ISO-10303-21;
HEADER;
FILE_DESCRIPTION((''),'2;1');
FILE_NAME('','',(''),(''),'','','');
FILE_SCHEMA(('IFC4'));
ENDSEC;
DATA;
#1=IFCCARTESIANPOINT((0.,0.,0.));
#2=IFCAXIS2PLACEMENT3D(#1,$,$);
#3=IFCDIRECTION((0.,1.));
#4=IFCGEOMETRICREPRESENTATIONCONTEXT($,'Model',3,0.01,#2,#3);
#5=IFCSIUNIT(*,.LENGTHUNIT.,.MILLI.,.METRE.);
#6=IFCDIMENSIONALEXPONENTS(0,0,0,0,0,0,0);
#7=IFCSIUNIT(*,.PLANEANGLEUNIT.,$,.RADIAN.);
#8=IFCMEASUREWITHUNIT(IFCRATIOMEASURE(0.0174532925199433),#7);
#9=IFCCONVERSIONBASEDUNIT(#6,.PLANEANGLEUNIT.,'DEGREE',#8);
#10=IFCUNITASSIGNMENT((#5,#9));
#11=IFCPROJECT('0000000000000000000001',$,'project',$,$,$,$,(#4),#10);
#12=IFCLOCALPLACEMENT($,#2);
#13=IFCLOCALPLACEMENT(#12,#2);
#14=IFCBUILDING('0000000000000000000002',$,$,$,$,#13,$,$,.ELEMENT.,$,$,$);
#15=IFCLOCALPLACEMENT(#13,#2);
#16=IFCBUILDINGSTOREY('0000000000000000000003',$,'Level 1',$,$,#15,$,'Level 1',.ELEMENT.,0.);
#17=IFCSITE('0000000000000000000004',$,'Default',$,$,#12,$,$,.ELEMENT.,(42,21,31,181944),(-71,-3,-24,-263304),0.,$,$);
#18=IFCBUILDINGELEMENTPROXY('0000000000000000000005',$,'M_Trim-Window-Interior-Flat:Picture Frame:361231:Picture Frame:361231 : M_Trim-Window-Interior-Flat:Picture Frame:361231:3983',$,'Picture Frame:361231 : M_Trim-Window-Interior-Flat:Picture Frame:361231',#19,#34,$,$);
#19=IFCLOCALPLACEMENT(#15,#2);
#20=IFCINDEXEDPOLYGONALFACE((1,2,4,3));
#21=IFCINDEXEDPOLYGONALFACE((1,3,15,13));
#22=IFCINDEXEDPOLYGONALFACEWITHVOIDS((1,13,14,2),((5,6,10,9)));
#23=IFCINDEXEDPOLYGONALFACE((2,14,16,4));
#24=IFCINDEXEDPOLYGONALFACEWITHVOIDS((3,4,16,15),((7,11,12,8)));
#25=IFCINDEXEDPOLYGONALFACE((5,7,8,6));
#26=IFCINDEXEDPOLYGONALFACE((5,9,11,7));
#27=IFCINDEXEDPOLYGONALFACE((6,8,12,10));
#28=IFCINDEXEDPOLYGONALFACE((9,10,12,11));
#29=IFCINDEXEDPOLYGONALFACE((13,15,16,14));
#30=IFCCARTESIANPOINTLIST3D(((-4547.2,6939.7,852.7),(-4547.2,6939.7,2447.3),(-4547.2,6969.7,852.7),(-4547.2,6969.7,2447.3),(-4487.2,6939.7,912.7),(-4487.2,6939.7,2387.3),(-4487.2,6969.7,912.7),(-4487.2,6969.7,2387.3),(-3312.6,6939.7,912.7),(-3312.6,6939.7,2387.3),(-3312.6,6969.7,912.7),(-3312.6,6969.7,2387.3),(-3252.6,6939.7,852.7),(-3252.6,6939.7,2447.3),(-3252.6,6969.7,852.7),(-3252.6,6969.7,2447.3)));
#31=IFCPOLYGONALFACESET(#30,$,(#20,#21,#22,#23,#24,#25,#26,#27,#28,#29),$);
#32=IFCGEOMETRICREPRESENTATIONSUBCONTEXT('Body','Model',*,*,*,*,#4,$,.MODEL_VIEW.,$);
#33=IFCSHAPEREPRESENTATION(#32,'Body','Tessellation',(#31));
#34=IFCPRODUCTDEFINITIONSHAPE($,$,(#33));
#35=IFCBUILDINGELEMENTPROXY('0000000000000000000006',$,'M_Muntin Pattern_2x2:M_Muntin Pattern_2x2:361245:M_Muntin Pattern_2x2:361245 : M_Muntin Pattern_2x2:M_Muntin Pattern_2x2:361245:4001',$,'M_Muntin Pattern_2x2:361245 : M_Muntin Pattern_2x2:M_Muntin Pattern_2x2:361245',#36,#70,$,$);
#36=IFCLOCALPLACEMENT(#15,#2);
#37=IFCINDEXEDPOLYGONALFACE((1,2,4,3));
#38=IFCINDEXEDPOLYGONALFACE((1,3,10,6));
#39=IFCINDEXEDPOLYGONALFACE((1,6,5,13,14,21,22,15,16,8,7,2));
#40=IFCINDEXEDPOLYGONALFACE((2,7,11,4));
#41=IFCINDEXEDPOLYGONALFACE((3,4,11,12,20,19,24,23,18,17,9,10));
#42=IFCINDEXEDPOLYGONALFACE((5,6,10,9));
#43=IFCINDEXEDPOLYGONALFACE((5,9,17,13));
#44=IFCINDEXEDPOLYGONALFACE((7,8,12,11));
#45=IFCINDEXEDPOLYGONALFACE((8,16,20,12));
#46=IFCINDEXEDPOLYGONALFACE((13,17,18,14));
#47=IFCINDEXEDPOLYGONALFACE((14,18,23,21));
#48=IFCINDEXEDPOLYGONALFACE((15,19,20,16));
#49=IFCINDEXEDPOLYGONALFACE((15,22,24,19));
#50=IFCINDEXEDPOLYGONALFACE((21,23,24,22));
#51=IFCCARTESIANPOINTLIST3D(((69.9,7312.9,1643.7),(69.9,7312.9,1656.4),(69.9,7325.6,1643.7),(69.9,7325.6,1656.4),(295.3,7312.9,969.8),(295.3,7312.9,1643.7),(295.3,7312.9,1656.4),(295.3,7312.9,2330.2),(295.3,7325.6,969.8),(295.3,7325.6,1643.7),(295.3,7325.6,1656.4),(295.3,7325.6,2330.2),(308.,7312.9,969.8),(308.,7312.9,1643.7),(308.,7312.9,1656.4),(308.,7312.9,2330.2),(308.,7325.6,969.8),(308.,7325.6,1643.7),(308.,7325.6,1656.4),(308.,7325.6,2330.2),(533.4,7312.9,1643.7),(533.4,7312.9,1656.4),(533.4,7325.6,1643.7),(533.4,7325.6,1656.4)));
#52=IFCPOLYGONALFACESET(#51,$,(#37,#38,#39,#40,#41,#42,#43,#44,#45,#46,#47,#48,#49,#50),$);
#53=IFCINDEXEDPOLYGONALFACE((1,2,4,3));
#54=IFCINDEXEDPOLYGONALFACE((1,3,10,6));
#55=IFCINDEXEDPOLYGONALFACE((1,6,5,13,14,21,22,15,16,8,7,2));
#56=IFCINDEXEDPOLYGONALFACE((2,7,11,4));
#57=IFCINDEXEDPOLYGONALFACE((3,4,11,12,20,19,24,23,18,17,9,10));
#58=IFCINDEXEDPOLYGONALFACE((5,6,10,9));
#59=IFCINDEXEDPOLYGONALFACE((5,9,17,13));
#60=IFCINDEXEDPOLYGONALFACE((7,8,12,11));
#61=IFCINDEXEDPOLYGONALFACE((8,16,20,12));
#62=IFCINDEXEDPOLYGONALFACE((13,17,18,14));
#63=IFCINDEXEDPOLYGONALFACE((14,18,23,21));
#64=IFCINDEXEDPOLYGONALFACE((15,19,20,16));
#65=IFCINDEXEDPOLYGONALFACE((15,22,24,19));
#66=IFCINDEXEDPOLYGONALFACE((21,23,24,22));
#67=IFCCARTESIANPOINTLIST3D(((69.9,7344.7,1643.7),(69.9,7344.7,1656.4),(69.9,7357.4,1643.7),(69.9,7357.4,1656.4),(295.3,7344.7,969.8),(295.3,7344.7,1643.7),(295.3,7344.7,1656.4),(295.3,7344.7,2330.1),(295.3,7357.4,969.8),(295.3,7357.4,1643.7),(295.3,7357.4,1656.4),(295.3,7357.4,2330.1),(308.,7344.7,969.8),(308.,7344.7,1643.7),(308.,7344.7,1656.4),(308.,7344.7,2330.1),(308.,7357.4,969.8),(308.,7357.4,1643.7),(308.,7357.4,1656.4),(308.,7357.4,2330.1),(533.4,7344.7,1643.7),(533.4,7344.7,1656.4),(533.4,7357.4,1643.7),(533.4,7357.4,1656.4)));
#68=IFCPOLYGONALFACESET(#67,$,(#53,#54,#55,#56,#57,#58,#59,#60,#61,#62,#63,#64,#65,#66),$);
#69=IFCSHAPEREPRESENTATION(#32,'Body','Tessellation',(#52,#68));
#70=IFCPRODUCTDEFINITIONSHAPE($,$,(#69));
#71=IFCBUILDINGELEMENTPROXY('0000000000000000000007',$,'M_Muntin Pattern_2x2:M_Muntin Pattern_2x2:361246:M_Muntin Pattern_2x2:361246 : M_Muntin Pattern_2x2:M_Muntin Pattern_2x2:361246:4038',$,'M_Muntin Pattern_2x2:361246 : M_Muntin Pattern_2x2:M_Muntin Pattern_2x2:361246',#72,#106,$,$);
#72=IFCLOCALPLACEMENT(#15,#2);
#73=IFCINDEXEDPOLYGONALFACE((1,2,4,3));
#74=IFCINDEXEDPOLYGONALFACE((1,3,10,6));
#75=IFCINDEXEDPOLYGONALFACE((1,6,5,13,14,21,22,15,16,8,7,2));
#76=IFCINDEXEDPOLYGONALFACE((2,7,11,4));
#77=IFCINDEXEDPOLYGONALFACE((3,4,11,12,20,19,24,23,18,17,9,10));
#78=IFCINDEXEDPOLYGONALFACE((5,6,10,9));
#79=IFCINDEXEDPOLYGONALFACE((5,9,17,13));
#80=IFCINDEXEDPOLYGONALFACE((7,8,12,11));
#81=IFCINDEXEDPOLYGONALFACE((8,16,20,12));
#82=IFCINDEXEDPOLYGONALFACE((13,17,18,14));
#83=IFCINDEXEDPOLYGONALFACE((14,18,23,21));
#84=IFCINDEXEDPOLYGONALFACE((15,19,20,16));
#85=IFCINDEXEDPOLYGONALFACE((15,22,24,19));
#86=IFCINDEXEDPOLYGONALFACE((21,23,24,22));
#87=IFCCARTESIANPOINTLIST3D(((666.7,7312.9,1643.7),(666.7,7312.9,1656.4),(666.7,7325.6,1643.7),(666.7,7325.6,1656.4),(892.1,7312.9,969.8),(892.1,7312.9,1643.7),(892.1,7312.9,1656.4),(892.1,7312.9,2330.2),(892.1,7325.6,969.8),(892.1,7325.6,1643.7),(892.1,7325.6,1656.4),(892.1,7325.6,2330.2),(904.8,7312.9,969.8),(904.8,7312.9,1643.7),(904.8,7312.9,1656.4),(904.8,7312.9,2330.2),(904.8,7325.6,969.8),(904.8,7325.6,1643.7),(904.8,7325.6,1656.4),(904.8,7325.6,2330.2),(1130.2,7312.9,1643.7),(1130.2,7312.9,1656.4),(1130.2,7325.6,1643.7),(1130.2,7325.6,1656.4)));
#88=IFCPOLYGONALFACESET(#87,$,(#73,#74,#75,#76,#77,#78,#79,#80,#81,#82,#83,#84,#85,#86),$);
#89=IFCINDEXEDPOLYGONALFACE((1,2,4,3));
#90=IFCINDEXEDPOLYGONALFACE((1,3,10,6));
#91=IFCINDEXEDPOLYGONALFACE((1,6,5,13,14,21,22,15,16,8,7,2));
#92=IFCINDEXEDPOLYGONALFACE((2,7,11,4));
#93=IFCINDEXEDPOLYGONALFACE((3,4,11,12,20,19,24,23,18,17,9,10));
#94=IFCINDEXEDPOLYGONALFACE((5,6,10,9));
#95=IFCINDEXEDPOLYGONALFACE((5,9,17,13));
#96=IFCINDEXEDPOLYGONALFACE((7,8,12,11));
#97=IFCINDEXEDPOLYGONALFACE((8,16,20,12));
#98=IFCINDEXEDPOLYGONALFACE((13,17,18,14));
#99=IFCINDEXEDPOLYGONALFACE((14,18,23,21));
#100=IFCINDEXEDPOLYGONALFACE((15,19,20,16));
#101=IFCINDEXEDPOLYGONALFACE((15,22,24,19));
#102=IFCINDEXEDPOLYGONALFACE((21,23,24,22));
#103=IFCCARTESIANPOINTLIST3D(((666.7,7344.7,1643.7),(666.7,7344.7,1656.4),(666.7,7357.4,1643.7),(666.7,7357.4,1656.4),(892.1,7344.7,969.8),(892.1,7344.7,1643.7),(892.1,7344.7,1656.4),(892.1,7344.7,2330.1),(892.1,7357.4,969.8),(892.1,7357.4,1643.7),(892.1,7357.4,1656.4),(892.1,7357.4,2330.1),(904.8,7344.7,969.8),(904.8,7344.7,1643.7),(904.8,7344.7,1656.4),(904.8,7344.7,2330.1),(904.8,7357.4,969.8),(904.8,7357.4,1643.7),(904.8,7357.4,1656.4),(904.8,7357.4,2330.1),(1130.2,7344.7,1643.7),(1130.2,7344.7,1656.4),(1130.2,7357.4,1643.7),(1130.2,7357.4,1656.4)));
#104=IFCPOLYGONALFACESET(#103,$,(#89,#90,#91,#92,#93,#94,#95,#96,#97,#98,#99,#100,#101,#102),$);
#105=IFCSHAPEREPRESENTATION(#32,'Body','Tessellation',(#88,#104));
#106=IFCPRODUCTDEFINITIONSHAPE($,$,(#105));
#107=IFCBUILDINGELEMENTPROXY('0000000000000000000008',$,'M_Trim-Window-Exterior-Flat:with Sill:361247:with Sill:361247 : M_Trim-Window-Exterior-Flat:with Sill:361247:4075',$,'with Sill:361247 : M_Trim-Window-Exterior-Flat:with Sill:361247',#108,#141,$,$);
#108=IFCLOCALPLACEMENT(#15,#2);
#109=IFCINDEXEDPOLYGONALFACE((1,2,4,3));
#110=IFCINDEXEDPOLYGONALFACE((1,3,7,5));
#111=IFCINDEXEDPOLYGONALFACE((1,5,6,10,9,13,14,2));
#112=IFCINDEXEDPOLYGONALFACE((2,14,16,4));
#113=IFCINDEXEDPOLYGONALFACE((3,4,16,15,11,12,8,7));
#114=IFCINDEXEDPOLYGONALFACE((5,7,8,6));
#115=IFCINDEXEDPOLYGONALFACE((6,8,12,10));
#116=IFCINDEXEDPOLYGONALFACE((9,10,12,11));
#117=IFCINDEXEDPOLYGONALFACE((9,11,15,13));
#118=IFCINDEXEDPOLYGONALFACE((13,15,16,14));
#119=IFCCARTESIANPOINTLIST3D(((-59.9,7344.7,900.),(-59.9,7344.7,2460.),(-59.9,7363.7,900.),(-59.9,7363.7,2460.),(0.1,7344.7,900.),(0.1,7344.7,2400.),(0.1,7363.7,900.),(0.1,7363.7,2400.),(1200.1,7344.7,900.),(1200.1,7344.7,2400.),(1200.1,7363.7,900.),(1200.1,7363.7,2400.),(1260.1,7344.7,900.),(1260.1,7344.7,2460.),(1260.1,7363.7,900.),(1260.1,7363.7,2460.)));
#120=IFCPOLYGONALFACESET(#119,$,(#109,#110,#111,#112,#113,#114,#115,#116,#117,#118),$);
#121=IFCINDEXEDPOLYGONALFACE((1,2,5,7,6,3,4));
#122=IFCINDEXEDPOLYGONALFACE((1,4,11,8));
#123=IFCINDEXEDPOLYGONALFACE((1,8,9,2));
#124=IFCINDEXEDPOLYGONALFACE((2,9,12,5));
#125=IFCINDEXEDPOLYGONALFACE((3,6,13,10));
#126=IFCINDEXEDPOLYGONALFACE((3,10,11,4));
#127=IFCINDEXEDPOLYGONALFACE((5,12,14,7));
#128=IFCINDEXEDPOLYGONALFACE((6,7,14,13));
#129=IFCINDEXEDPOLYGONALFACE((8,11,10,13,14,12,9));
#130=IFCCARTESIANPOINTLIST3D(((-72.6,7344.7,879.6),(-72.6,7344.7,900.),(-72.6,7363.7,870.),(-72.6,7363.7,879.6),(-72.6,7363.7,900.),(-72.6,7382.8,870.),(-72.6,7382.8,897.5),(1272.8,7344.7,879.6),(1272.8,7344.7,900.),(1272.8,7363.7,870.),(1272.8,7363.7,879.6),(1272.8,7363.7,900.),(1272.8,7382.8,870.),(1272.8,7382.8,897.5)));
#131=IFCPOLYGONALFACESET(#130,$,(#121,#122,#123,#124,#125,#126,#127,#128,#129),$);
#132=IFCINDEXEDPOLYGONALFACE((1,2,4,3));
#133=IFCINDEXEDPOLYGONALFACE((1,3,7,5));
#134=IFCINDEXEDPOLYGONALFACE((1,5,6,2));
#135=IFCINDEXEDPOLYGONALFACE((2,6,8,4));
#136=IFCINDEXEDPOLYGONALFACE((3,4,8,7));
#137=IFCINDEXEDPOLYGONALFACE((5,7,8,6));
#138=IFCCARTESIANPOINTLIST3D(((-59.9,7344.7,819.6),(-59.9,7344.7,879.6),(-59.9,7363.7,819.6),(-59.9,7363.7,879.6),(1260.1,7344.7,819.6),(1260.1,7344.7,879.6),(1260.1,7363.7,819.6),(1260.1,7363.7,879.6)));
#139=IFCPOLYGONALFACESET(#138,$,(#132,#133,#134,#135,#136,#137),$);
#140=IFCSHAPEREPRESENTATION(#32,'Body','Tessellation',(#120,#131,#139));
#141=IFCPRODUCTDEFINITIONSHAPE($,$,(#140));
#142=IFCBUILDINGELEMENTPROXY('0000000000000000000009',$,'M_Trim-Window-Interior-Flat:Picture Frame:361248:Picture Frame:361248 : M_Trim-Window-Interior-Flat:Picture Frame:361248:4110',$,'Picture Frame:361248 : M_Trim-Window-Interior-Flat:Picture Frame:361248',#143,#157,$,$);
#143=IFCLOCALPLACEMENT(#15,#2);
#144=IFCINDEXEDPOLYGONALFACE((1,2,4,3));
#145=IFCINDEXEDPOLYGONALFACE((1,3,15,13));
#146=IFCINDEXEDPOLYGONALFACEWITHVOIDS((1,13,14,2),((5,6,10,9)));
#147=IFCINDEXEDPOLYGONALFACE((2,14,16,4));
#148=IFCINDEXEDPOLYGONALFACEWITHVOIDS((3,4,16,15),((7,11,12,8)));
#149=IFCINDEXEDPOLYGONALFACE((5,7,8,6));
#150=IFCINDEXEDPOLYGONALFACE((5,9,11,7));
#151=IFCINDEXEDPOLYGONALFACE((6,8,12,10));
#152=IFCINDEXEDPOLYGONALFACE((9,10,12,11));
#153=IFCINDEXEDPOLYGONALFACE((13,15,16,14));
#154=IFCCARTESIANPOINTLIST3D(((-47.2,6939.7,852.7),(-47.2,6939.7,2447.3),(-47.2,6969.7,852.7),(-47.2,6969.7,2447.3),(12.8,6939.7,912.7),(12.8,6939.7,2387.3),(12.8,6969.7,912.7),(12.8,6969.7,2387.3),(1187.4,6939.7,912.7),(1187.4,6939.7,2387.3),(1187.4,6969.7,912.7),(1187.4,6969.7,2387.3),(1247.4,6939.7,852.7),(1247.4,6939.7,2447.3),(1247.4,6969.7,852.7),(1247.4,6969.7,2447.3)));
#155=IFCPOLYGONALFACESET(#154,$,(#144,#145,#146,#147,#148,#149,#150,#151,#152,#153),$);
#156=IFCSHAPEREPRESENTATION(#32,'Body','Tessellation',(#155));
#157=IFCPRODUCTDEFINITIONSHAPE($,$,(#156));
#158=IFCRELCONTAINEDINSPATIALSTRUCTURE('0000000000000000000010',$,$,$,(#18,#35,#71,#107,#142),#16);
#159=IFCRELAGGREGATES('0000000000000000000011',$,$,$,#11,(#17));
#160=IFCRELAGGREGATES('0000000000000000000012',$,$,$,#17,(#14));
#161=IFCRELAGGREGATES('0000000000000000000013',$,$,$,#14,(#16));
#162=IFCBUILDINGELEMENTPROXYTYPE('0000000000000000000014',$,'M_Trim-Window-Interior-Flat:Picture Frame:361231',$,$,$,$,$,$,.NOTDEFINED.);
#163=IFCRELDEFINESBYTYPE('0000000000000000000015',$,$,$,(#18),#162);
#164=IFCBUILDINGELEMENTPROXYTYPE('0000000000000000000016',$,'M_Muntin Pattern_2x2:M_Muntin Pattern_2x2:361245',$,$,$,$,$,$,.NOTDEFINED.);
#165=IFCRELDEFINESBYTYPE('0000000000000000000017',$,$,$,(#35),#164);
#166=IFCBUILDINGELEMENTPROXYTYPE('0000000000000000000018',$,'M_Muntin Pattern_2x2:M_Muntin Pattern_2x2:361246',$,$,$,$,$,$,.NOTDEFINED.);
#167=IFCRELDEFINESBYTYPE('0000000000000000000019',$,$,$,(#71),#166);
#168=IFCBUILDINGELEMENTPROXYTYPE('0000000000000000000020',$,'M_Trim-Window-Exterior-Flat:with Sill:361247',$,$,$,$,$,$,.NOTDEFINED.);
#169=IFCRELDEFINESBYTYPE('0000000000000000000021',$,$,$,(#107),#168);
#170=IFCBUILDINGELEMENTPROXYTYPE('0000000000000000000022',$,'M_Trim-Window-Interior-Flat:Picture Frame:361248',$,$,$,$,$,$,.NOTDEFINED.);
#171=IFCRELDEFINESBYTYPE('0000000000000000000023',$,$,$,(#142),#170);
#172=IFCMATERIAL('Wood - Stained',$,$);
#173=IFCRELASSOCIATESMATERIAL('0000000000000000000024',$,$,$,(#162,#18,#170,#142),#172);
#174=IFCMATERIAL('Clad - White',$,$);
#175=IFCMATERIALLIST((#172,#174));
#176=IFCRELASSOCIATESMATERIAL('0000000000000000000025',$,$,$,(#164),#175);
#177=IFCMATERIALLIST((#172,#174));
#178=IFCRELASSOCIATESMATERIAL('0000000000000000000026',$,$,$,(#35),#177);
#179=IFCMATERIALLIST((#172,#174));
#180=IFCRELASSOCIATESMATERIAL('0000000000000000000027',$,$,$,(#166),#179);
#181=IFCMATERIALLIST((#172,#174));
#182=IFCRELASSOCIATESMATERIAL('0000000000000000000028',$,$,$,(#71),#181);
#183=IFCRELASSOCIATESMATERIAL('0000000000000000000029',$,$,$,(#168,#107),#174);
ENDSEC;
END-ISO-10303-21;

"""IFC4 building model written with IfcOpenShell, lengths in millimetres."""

from ifc_helpers import new_model, entity, si_unit, converted_unit, direction, frame, origin, origin_2d_with_axis, place, context, subcontext, project, spatial, polyline, rectangle, outline, extrude, source, transform, mapped, material, material_list, type_object, type_shapes, element, save


model = new_model("IFC4")

# Units and contexts
model_context = context("Model", 3, precision=0.01, world=origin(), true_north=direction((0.0, 1.0)))
body_context = subcontext(model_context, "Body", "Model", "MODEL_VIEW")
ifc_project = project(units=[si_unit("LENGTHUNIT", "METRE", prefix="MILLI"), converted_unit("PLANEANGLEUNIT", "DEGREE", entity("IfcRatioMeasure", 0.0174532925199433), si_unit("PLANEANGLEUNIT", "RADIAN"), dimensions=[0, 0, 0, 0, 0, 0, 0])], contexts=[model_context])

# Site, building, storey
site_placement = place(None, origin())
site = spatial("IfcSite", under=ifc_project, at=site_placement, Name="Default", CompositionType="ELEMENT", RefLatitude=(42, 21, 31, 181944), RefLongitude=(-71, -3, -24, -263304), RefElevation=0.0)
building_placement = place(site_placement, origin())
building = spatial("IfcBuilding", under=site, at=building_placement, CompositionType="ELEMENT")
storey_placement = place(building_placement, origin())
storey = spatial("IfcBuildingStorey", under=building, at=storey_placement, Name="Level 1", LongName="Level 1", CompositionType="ELEMENT", Elevation=0.0)

# Building element proxies
ifc_material_1 = material(Name="Wood - Stained")
ifc_material_2 = material(Name="Clad - White")
building_element_proxy_type_1 = type_object("IfcBuildingElementProxyType", Name="M_Trim-Window-Interior-Flat:Picture Frame:361231", PredefinedType="NOTDEFINED", material=ifc_material_1)
shared_shape_1 = source(origin(), body_context, "Body", "SweptSolid", [
    extrude(outline(polyline([(-647.3, -797.3), (647.3, -797.3), (647.3, 797.3), (-647.3, 797.3), (-647.3, -797.3)]), holes=[polyline([(587.3, 737.3), (587.3, -737.3), (-587.3, -737.3), (-587.3, 737.3), (587.3, 737.3)])]), frame((-3899.9, 6939.7, 1650.0), z_axis=(0.0, 1.0, 0.0), x_axis=(1.0, 0.0, 0.0)), (0.0, 0.0, 1.0), 30.0),
])
type_shapes(building_element_proxy_type_1, [shared_shape_1])
proxy_1_placement = place(storey_placement, origin())
element("IfcBuildingElementProxy", 1, at=proxy_1_placement, inside=storey, type_object=building_element_proxy_type_1, material=ifc_material_1, Name="M_Trim-Window-Interior-Flat:Picture Frame:361231:Picture Frame:361231 : M_Trim-Window-Interior-Flat:Picture Frame:361231:3983", ObjectType="Picture Frame:361231 : M_Trim-Window-Interior-Flat:Picture Frame:361231", context=body_context, shape_type="MappedRepresentation", body=[
    mapped(shared_shape_1, transform((0.0, 0.0, 0.0), scale=1.0)),
])
ifc_material_list_1 = material_list([ifc_material_1, ifc_material_2])
ifc_material_list_2 = material_list([ifc_material_1, ifc_material_2])
building_element_proxy_type_2 = type_object("IfcBuildingElementProxyType", Name="M_Muntin Pattern_2x2:M_Muntin Pattern_2x2:361245", PredefinedType="NOTDEFINED", material=ifc_material_list_2)
shared_shape_2 = source(origin(), body_context, "Body", "SweptSolid", [
    extrude(outline(polyline([(-6.4, -680.2), (6.3, -680.2), (6.3, -6.4), (231.7, -6.4), (231.7, 6.3), (6.3, 6.3), (6.3, 680.2), (-6.4, 680.2), (-6.4, 6.3), (-231.7, 6.3), (-231.7, -6.4), (-6.4, -6.4), (-6.4, -680.2)])), frame((301.6, 7312.9, 1650.0), z_axis=(0.0, 1.0, 0.0), x_axis=(1.0, 0.0, 0.0)), (0.0, 0.0, 1.0), 12.7),
    extrude(outline(polyline([(-6.4, -680.1), (6.3, -680.1), (6.3, -6.4), (231.7, -6.4), (231.7, 6.3), (6.3, 6.3), (6.3, 680.2), (-6.4, 680.2), (-6.4, 6.3), (-231.7, 6.3), (-231.7, -6.4), (-6.4, -6.4), (-6.4, -680.1)])), frame((301.6, 7344.7, 1650.0), z_axis=(0.0, 1.0, 0.0), x_axis=(1.0, 0.0, 0.0)), (0.0, 0.0, 1.0), 12.7),
])
type_shapes(building_element_proxy_type_2, [shared_shape_2])
proxy_2_placement = place(storey_placement, origin())
element("IfcBuildingElementProxy", 2, at=proxy_2_placement, inside=storey, type_object=building_element_proxy_type_2, material=ifc_material_list_1, Name="M_Muntin Pattern_2x2:M_Muntin Pattern_2x2:361245:M_Muntin Pattern_2x2:361245 : M_Muntin Pattern_2x2:M_Muntin Pattern_2x2:361245:4001", ObjectType="M_Muntin Pattern_2x2:361245 : M_Muntin Pattern_2x2:M_Muntin Pattern_2x2:361245", context=body_context, shape_type="MappedRepresentation", body=[
    mapped(shared_shape_2, transform((0.0, 0.0, 0.0), scale=1.0)),
])
ifc_material_list_3 = material_list([ifc_material_1, ifc_material_2])
ifc_material_list_4 = material_list([ifc_material_1, ifc_material_2])
building_element_proxy_type_3 = type_object("IfcBuildingElementProxyType", Name="M_Muntin Pattern_2x2:M_Muntin Pattern_2x2:361246", PredefinedType="NOTDEFINED", material=ifc_material_list_4)
shared_shape_3 = source(origin(), body_context, "Body", "SweptSolid", [
    extrude(outline(polyline([(-680.1, 6.4), (-680.1, -6.3), (-6.4, -6.3), (-6.4, -231.7), (6.3, -231.7), (6.3, -6.3), (680.2, -6.3), (680.2, 6.4), (6.3, 6.4), (6.3, 231.7), (-6.4, 231.7), (-6.4, 6.4), (-680.1, 6.4)])), frame((898.5, 7312.9, 1650.0), z_axis=(0.0, -1.0, 0.0), x_axis=(0.0, 0.0, -1.0)), (0.0, 0.0, -1.0), 12.7),
    extrude(outline(polyline([(-680.1, 6.4), (-680.1, -6.3), (-6.4, -6.3), (-6.4, -231.7), (6.3, -231.7), (6.3, -6.3), (680.2, -6.3), (680.2, 6.4), (6.3, 6.4), (6.3, 231.7), (-6.4, 231.7), (-6.4, 6.4), (-680.1, 6.4)])), frame((898.5, 7344.7, 1650.0), z_axis=(0.0, -1.0, 0.0), x_axis=(0.0, 0.0, -1.0)), (0.0, 0.0, -1.0), 12.7),
])
type_shapes(building_element_proxy_type_3, [shared_shape_3])
proxy_3_placement = place(storey_placement, origin())
element("IfcBuildingElementProxy", 3, at=proxy_3_placement, inside=storey, type_object=building_element_proxy_type_3, material=ifc_material_list_3, Name="M_Muntin Pattern_2x2:M_Muntin Pattern_2x2:361246:M_Muntin Pattern_2x2:361246 : M_Muntin Pattern_2x2:M_Muntin Pattern_2x2:361246:4038", ObjectType="M_Muntin Pattern_2x2:361246 : M_Muntin Pattern_2x2:M_Muntin Pattern_2x2:361246", context=body_context, shape_type="MappedRepresentation", body=[
    mapped(shared_shape_3, transform((0.0, 0.0, 0.0), scale=1.0)),
])
building_element_proxy_type_4 = type_object("IfcBuildingElementProxyType", Name="M_Trim-Window-Exterior-Flat:with Sill:361247", PredefinedType="NOTDEFINED", material=ifc_material_2)
shared_shape_4 = source(origin(), body_context, "Body", "SweptSolid", [
    extrude(outline(polyline([(-660.0, -765.0), (-600.0, -765.0), (-600.0, 735.0), (600.0, 735.0), (600.0, -765.0), (660.0, -765.0), (660.0, 795.0), (-660.0, 795.0), (-660.0, -765.0)])), frame((600.1, 7344.7, 1665.0), z_axis=(0.0, 1.0, 0.0), x_axis=(-1.0, 0.0, 0.0)), (0.0, 0.0, 1.0), 19.1),
    extrude(outline(polyline([(0.0, -15.2), (19.0, -15.2), (19.0, 12.3), (0.0, 14.8), (-19.0, 14.8), (-19.0, -5.7), (0.0, -5.7), (0.0, -15.2)])), frame((-72.6, 7363.7, 885.2), z_axis=(1.0, 0.0, 0.0), x_axis=(0.0, 1.0, 0.0)), (0.0, 0.0, 1.0), 1345.4),
    extrude(rectangle(XDim=19.1, YDim=1320.0, at=origin_2d_with_axis()), frame((600.1, 7354.2, 819.6), z_axis=(0.0, 0.0, 1.0), x_axis=(0.0, -1.0, 0.0)), (0.0, 0.0, 1.0), 60.0),
])
type_shapes(building_element_proxy_type_4, [shared_shape_4])
proxy_4_placement = place(storey_placement, origin())
element("IfcBuildingElementProxy", 4, at=proxy_4_placement, inside=storey, type_object=building_element_proxy_type_4, material=ifc_material_2, Name="M_Trim-Window-Exterior-Flat:with Sill:361247:with Sill:361247 : M_Trim-Window-Exterior-Flat:with Sill:361247:4075", ObjectType="with Sill:361247 : M_Trim-Window-Exterior-Flat:with Sill:361247", context=body_context, shape_type="MappedRepresentation", body=[
    mapped(shared_shape_4, transform((0.0, 0.0, 0.0), scale=1.0)),
])
building_element_proxy_type_5 = type_object("IfcBuildingElementProxyType", Name="M_Trim-Window-Interior-Flat:Picture Frame:361248", PredefinedType="NOTDEFINED", material=ifc_material_1)
shared_shape_5 = source(origin(), body_context, "Body", "SweptSolid", [
    extrude(outline(polyline([(-647.3, -797.3), (647.3, -797.3), (647.3, 797.3), (-647.3, 797.3), (-647.3, -797.3)]), holes=[polyline([(587.3, 737.3), (587.3, -737.3), (-587.3, -737.3), (-587.3, 737.3), (587.3, 737.3)])]), frame((600.1, 6939.7, 1650.0), z_axis=(0.0, 1.0, 0.0), x_axis=(1.0, 0.0, 0.0)), (0.0, 0.0, 1.0), 30.0),
])
type_shapes(building_element_proxy_type_5, [shared_shape_5])
proxy_5_placement = place(storey_placement, origin())
element("IfcBuildingElementProxy", 5, at=proxy_5_placement, inside=storey, type_object=building_element_proxy_type_5, material=ifc_material_1, Name="M_Trim-Window-Interior-Flat:Picture Frame:361248:Picture Frame:361248 : M_Trim-Window-Interior-Flat:Picture Frame:361248:4110", ObjectType="Picture Frame:361248 : M_Trim-Window-Interior-Flat:Picture Frame:361248", context=body_context, shape_type="MappedRepresentation", body=[
    mapped(shared_shape_5, transform((0.0, 0.0, 0.0), scale=1.0)),
])

save(model, "model.ifc")
